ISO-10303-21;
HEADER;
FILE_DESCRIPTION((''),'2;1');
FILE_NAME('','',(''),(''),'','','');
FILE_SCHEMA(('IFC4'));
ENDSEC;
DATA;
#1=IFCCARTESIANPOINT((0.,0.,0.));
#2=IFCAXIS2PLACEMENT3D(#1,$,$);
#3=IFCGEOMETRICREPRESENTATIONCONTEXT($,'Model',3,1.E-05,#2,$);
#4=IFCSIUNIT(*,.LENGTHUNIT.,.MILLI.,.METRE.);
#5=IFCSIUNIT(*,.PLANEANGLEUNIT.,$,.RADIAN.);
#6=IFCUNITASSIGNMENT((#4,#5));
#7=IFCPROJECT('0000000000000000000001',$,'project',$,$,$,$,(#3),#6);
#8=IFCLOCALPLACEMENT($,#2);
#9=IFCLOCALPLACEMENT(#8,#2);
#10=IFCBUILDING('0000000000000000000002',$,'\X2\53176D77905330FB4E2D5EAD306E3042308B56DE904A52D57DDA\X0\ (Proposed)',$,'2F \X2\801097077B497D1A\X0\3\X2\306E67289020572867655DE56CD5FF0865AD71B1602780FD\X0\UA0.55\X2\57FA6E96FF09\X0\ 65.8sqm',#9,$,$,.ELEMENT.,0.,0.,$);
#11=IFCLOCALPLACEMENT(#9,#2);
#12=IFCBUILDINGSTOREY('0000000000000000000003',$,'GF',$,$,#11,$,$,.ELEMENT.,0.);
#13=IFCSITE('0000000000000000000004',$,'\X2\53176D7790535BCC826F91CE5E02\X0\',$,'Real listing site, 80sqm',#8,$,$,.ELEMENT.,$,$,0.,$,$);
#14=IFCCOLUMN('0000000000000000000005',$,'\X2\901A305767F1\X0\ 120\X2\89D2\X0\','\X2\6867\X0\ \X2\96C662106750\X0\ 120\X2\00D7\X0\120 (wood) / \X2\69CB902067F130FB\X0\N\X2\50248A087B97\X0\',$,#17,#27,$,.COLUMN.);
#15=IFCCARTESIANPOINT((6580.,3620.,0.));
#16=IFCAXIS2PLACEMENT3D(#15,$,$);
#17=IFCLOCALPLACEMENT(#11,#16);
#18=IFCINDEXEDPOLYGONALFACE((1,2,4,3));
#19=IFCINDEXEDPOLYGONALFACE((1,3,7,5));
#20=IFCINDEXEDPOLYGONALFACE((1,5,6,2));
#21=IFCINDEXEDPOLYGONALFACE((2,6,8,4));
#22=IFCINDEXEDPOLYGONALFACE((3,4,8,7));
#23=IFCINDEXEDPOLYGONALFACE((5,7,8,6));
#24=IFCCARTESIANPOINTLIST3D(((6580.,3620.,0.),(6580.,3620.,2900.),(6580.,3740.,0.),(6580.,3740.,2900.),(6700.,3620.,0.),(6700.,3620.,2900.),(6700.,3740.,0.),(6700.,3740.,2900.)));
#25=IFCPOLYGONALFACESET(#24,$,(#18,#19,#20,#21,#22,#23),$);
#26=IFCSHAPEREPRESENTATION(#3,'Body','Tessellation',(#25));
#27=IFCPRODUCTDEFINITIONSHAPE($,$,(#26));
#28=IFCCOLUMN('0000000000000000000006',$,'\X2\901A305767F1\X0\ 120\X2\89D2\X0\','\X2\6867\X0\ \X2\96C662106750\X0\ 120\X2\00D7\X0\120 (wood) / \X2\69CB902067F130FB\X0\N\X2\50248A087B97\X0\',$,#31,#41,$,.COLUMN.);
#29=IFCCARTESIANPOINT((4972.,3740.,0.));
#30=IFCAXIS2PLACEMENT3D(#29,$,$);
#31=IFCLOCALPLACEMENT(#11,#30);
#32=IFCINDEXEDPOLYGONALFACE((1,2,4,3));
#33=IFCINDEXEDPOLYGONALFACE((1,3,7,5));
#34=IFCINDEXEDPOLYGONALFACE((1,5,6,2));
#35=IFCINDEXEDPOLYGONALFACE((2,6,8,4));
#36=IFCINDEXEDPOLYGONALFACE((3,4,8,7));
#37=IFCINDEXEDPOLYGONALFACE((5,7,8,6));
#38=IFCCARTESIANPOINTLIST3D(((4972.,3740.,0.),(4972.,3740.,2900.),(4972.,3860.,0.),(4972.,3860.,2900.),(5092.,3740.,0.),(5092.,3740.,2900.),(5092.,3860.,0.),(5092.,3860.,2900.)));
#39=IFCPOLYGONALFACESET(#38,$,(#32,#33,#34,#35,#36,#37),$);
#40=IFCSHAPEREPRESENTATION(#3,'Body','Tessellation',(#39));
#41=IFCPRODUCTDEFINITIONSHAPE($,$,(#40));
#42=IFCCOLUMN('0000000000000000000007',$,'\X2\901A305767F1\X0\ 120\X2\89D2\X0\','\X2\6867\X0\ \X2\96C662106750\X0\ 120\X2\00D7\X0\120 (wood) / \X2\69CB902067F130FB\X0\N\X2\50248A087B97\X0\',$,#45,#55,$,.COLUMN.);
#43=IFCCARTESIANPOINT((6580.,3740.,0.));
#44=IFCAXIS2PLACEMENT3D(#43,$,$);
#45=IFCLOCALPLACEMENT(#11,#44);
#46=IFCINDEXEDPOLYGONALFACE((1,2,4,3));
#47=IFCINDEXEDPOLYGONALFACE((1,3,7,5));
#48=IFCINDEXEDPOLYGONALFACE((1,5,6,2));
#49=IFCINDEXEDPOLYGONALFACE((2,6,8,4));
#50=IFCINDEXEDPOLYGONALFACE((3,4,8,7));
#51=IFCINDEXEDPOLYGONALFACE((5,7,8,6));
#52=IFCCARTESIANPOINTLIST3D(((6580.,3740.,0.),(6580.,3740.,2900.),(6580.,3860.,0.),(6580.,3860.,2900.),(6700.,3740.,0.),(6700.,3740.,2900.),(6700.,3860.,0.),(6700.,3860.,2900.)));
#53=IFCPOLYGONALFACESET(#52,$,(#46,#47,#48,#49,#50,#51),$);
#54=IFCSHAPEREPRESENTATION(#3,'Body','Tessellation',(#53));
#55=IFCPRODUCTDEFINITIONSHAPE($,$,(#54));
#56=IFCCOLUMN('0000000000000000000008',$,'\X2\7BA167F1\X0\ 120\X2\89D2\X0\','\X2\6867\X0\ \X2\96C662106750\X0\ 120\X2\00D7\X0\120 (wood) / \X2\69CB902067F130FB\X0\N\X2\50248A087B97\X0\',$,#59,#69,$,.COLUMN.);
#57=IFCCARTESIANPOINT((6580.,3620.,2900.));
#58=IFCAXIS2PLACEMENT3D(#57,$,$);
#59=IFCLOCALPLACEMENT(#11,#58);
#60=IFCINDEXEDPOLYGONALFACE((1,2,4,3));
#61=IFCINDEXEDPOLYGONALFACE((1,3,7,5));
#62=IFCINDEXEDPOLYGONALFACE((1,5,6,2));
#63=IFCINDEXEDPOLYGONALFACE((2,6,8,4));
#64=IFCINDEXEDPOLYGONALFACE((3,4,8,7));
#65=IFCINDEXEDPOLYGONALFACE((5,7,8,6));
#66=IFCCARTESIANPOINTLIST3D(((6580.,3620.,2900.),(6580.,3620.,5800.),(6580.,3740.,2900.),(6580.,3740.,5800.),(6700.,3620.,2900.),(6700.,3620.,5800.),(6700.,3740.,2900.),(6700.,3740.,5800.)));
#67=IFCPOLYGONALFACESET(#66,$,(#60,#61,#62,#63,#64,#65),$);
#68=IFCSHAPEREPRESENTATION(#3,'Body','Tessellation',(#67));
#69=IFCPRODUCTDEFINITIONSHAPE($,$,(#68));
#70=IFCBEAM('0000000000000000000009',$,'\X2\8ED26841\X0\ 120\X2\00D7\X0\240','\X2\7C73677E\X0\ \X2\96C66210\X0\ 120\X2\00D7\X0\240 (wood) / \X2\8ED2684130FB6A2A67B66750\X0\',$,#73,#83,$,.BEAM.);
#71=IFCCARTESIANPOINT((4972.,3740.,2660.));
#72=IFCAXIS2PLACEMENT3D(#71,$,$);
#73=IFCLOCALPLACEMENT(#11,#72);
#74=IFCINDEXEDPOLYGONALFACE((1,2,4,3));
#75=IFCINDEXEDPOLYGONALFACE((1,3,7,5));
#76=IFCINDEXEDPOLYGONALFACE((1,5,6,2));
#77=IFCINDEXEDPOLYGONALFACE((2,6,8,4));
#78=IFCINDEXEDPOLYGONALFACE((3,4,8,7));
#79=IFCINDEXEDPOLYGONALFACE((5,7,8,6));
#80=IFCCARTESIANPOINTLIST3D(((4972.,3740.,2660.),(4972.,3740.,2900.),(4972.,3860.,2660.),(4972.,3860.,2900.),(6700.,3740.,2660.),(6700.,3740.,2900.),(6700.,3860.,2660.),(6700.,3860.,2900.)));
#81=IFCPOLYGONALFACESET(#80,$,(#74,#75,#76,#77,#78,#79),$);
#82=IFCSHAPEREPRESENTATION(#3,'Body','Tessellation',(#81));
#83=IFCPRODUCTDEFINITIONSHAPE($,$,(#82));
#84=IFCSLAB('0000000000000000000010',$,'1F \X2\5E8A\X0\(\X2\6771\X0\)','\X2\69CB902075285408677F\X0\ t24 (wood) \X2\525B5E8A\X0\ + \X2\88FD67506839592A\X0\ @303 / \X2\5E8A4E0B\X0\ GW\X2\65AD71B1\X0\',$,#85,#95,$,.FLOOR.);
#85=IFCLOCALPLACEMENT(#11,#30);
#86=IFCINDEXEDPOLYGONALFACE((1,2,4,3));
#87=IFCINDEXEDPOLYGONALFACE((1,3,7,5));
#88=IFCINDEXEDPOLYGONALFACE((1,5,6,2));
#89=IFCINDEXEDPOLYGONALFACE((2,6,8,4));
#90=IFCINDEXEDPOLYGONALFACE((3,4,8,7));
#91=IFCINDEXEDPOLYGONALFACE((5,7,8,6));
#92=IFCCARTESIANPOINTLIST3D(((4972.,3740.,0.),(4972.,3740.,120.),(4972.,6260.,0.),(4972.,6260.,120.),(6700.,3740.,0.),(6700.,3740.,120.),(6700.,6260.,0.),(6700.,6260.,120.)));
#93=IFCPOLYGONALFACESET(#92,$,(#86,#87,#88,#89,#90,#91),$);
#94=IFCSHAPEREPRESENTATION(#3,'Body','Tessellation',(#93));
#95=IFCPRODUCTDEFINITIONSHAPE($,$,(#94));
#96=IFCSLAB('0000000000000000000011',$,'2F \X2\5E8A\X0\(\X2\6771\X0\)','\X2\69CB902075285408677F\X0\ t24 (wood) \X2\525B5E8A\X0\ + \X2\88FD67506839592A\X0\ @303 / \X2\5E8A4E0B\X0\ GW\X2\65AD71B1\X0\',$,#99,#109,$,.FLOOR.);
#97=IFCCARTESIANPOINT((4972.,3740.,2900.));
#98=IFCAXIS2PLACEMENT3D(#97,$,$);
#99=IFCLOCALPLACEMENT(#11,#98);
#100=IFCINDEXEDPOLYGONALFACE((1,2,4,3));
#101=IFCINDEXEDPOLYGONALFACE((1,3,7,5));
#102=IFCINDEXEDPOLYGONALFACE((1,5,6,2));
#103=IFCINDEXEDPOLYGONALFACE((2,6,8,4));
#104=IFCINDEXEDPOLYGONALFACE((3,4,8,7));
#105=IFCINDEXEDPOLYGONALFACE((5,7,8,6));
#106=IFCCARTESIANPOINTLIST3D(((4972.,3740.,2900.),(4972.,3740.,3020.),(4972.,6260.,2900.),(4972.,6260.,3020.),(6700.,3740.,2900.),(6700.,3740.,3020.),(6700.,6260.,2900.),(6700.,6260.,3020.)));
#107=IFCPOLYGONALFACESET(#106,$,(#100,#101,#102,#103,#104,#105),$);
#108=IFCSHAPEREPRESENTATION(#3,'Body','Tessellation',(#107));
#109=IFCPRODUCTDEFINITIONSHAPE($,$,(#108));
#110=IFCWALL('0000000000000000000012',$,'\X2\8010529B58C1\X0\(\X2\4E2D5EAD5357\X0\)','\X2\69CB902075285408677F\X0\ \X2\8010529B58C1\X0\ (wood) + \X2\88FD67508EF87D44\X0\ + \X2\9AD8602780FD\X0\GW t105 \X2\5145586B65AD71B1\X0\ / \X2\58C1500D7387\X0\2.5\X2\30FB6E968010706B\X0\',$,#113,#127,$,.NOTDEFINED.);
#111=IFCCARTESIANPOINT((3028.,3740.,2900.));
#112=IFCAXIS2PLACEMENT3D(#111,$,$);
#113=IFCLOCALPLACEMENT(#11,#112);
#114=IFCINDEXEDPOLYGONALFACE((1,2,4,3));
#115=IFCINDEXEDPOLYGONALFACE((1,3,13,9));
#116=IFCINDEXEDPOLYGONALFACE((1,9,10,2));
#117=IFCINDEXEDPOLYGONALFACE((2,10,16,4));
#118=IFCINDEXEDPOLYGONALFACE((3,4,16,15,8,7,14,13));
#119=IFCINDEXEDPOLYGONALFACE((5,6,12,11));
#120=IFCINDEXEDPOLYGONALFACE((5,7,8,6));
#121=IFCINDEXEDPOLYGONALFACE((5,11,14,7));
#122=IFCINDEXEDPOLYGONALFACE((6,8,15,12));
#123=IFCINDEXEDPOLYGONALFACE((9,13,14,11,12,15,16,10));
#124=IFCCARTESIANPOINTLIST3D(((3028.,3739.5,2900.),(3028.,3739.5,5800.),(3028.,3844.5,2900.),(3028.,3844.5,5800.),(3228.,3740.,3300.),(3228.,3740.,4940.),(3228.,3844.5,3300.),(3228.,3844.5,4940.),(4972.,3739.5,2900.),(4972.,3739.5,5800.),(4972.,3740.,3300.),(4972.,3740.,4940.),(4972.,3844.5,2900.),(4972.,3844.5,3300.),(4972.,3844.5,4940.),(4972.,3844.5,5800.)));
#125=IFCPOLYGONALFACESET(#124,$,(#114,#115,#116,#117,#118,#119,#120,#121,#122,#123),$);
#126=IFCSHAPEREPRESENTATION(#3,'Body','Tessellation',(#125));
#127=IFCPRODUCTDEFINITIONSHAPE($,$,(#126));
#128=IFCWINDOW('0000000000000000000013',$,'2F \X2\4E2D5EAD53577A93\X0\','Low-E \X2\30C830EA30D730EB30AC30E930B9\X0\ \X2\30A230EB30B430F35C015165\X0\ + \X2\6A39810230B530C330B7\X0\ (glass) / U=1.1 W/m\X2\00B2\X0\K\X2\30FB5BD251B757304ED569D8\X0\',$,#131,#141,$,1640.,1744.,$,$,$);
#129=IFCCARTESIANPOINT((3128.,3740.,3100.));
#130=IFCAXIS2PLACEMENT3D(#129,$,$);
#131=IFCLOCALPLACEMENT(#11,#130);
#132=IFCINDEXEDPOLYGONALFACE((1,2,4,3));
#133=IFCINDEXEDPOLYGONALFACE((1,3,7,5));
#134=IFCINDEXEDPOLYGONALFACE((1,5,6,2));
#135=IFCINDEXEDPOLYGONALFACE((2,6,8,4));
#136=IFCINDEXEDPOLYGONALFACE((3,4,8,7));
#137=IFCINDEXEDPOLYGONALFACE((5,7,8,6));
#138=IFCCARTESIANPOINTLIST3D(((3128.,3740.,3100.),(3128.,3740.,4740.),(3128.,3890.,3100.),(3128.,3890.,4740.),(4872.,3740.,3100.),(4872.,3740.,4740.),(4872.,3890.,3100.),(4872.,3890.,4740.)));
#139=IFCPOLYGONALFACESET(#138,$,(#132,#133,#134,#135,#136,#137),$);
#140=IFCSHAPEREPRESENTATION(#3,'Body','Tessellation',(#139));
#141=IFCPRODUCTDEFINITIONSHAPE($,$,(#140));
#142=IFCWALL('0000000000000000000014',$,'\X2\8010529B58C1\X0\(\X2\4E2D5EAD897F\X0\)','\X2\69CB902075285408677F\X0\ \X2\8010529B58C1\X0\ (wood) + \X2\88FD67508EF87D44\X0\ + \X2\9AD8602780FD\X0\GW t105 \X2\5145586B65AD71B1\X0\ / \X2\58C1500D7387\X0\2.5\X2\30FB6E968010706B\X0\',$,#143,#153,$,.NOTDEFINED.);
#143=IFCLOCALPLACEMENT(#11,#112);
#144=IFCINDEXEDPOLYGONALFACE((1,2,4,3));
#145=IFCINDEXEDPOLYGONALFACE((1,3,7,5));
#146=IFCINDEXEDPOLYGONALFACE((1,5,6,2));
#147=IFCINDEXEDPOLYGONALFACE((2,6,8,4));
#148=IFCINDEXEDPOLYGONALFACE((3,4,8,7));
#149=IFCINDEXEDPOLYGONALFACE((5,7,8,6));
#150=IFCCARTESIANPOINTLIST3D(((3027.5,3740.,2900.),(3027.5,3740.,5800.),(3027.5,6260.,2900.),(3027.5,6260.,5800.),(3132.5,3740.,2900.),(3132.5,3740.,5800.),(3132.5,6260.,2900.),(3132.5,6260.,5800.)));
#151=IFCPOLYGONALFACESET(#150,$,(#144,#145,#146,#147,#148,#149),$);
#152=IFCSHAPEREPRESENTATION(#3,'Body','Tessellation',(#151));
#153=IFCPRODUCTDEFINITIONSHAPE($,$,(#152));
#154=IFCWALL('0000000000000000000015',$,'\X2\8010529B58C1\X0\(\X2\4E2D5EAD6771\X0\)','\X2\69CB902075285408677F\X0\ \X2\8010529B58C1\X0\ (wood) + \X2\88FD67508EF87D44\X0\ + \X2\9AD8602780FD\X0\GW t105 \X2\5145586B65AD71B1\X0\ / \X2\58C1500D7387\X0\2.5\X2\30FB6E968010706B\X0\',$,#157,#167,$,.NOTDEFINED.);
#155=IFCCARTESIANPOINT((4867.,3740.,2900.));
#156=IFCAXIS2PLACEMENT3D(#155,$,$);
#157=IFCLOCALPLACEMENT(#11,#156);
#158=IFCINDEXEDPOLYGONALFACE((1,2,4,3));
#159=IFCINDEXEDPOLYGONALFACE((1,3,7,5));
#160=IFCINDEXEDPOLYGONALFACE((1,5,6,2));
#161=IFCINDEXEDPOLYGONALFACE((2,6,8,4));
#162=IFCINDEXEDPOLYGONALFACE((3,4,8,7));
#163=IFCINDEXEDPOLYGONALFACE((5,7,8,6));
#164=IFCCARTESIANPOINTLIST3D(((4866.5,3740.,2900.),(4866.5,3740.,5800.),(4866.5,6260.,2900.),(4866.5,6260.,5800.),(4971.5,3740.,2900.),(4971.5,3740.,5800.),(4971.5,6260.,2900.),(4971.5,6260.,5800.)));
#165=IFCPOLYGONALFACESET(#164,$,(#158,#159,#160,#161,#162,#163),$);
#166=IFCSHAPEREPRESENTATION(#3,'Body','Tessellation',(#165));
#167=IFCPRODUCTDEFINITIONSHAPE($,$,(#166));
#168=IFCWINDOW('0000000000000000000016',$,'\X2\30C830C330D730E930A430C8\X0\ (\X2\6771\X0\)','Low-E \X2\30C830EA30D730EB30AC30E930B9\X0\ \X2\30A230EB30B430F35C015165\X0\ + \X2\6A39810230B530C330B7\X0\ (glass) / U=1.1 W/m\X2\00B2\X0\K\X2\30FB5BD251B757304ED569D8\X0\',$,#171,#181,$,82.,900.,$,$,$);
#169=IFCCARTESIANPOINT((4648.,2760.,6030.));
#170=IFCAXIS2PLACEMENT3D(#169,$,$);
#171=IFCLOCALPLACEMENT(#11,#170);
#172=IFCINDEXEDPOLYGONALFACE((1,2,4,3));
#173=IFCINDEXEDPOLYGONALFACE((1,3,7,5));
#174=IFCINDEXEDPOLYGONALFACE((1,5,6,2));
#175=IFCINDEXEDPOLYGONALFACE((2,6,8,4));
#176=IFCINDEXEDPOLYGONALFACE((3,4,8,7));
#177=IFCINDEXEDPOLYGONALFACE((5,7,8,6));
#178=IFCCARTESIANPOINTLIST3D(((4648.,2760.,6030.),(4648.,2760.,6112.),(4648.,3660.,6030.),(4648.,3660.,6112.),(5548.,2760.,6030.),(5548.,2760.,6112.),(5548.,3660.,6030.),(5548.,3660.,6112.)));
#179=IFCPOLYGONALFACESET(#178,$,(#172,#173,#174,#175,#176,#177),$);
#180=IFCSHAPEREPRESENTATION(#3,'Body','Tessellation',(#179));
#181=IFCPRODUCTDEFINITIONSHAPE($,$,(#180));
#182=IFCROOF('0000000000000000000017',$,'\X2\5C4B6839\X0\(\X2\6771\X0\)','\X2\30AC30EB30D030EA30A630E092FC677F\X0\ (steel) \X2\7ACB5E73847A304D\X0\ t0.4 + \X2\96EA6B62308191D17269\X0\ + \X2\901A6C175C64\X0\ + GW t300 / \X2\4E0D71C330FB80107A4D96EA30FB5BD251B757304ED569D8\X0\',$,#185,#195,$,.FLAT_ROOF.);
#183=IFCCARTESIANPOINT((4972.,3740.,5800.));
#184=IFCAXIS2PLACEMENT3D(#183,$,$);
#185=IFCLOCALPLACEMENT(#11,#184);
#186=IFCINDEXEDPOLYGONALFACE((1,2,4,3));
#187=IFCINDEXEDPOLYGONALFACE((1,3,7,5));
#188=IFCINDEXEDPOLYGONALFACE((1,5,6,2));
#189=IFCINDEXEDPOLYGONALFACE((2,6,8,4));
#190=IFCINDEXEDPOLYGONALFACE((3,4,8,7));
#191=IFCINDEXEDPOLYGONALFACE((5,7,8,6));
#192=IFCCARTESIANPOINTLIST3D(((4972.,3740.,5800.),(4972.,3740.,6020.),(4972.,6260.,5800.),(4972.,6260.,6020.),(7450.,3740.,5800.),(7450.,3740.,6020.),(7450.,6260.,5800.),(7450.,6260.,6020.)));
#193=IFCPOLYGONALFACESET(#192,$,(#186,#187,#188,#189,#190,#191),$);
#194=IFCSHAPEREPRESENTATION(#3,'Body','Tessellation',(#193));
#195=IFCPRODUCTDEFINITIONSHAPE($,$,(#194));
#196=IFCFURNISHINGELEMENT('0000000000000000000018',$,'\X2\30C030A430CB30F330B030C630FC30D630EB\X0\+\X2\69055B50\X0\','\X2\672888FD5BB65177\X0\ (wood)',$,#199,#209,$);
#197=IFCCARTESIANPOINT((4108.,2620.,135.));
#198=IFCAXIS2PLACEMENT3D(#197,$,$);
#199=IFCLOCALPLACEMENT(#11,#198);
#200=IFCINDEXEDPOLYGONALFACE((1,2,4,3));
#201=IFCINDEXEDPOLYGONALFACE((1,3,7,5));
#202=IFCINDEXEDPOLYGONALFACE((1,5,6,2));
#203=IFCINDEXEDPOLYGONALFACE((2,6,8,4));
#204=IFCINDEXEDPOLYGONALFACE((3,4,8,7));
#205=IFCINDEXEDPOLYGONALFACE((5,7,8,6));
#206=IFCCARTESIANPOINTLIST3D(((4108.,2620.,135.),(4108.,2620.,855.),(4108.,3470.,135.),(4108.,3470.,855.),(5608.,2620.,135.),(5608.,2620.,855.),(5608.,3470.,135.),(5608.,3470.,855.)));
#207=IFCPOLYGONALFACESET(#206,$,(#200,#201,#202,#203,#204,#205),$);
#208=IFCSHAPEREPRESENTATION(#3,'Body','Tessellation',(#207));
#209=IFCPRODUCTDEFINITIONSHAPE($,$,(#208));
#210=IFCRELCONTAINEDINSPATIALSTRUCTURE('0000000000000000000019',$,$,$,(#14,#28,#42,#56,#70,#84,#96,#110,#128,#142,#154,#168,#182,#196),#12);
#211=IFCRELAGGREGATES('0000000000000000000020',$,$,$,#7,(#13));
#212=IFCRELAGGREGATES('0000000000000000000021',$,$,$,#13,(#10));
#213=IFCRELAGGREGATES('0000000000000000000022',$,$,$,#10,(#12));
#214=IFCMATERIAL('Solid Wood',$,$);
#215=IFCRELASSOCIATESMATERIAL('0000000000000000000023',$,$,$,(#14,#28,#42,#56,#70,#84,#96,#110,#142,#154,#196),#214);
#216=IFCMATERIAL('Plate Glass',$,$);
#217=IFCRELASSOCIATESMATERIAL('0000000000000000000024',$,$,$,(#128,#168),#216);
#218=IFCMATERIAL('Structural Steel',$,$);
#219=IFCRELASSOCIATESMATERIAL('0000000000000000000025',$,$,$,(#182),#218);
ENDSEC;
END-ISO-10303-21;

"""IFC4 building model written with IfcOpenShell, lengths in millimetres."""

from ifc_helpers import new_model, si_unit, frame, frame_2d, origin, place, context, project, spatial, rectangle, extrude, material, element, fill, save


model = new_model("IFC4")

# Units and contexts
model_context = context("Model", 3, precision=1e-05, world=origin())
ifc_project = project(units=[si_unit("LENGTHUNIT", "METRE", prefix="MILLI"), si_unit("PLANEANGLEUNIT", "RADIAN")], contexts=[model_context])

# Site, building, storey
site_placement = place(None, origin())
site = spatial("IfcSite", under=ifc_project, at=site_placement, Name="北海道富良野市", ObjectType="Real listing site, 80sqm", CompositionType="ELEMENT", RefElevation=0.0)
building_placement = place(site_placement, origin())
building = spatial("IfcBuilding", under=site, at=building_placement, Name="北海道・中庭のある回遊動線 (Proposed)", ObjectType="2F 耐震等級3の木造在来工法（断熱性能UA0.55基準） 65.8sqm", CompositionType="ELEMENT", ElevationOfRefHeight=0.0, ElevationOfTerrain=0.0)
storey_placement = place(building_placement, origin())
storey = spatial("IfcBuildingStorey", under=building, at=storey_placement, Name="GF", CompositionType="ELEMENT", Elevation=0.0)

# Columns
ifc_material_1 = material(Name="Solid Wood")
column_1_placement = place(storey_placement, frame((6580.0, 3620.0, 0.0)))
element("IfcColumn", 1, at=column_1_placement, inside=storey, material=ifc_material_1, Name="通し柱 120角", Description="桧 集成材 120×120 (wood) / 構造柱・N値計算", PredefinedType="COLUMN", context=model_context, shape_type="SweptSolid", body=[
    extrude(rectangle(XDim=120.0, YDim=120.0, at=frame_2d((60.0, 60.0))), frame((6580.0, 3620.0, 0.0)), (0.0, 0.0, 1.0), 2900.0),
])
column_2_placement = place(storey_placement, frame((4972.0, 3740.0, 0.0)))
element("IfcColumn", 2, at=column_2_placement, inside=storey, material=ifc_material_1, Name="通し柱 120角", Description="桧 集成材 120×120 (wood) / 構造柱・N値計算", PredefinedType="COLUMN", context=model_context, shape_type="SweptSolid", body=[
    extrude(rectangle(XDim=120.0, YDim=120.0, at=frame_2d((60.0, 60.0))), frame((4972.0, 3740.0, 0.0)), (0.0, 0.0, 1.0), 2900.0),
])
column_3_placement = place(storey_placement, frame((6580.0, 3740.0, 0.0)))
element("IfcColumn", 3, at=column_3_placement, inside=storey, material=ifc_material_1, Name="通し柱 120角", Description="桧 集成材 120×120 (wood) / 構造柱・N値計算", PredefinedType="COLUMN", context=model_context, shape_type="SweptSolid", body=[
    extrude(rectangle(XDim=120.0, YDim=120.0, at=frame_2d((60.0, 60.0))), frame((6580.0, 3740.0, 0.0)), (0.0, 0.0, 1.0), 2900.0),
])
column_4_placement = place(storey_placement, frame((6580.0, 3620.0, 2900.0)))
element("IfcColumn", 4, at=column_4_placement, inside=storey, material=ifc_material_1, Name="管柱 120角", Description="桧 集成材 120×120 (wood) / 構造柱・N値計算", PredefinedType="COLUMN", context=model_context, shape_type="SweptSolid", body=[
    extrude(rectangle(XDim=120.0, YDim=120.0, at=frame_2d((60.0, 60.0))), frame((6580.0, 3620.0, 2900.0)), (0.0, 0.0, 1.0), 2900.0),
])

# Beam
beam_1_placement = place(storey_placement, frame((4972.0, 3740.0, 2660.0)))
element("IfcBeam", 5, at=beam_1_placement, inside=storey, material=ifc_material_1, Name="軒桁 120×240", Description="米松 集成 120×240 (wood) / 軒桁・横架材", PredefinedType="BEAM", context=model_context, shape_type="SweptSolid", body=[
    extrude(rectangle(XDim=1728.0, YDim=120.0, at=frame_2d((864.0, 60.0))), frame((4972.0, 3740.0, 2660.0)), (0.0, 0.0, 1.0), 240.0),
])

# Slabs
slab_1_placement = place(storey_placement, frame((4972.0, 3740.0, 0.0)))
element("IfcSlab", 6, at=slab_1_placement, inside=storey, material=ifc_material_1, Name="1F 床(東)", Description="構造用合板 t24 (wood) 剛床 + 製材根太 @303 / 床下 GW断熱", PredefinedType="FLOOR", context=model_context, shape_type="SweptSolid", body=[
    extrude(rectangle(XDim=1728.0, YDim=2520.0, at=frame_2d((864.0, 1260.0))), frame((4972.0, 3740.0, 0.0)), (0.0, 0.0, 1.0), 120.0),
])
slab_2_placement = place(storey_placement, frame((4972.0, 3740.0, 2900.0)))
element("IfcSlab", 7, at=slab_2_placement, inside=storey, material=ifc_material_1, Name="2F 床(東)", Description="構造用合板 t24 (wood) 剛床 + 製材根太 @303 / 床下 GW断熱", PredefinedType="FLOOR", context=model_context, shape_type="SweptSolid", body=[
    extrude(rectangle(XDim=1728.0, YDim=2520.0, at=frame_2d((864.0, 1260.0))), frame((4972.0, 3740.0, 2900.0)), (0.0, 0.0, 1.0), 120.0),
])

# Wall, opening, window
wall_1_placement = place(storey_placement, frame((3028.0, 3740.0, 2900.0)))
wall_1 = element("IfcWall", 8, at=wall_1_placement, inside=storey, material=ifc_material_1, Name="耐力壁(中庭南)", Description="構造用合板 耐力壁 (wood) + 製材軸組 + 高性能GW t105 充填断熱 / 壁倍率2.5・準耐火", PredefinedType="NOTDEFINED", context=model_context, shape_type="SweptSolid", body=[
    extrude(rectangle(XDim=1944.0, YDim=105.0, at=frame_2d((972.0, 52.0))), frame((3028.0, 3740.0, 2900.0)), (0.0, 0.0, 1.0), 2900.0),
])
opening_placement = place(storey_placement, frame((3128.0, 3740.0, 3100.0)))
opening = element("IfcOpeningElement", 9, at=opening_placement, cuts=wall_1, PredefinedType="NOTDEFINED", context=model_context, shape_type="SweptSolid", body=[
    extrude(rectangle(XDim=1744.0, YDim=150.0, at=frame_2d((872.0, 75.0))), frame((3128.0, 3740.0, 3100.0)), (0.0, 0.0, 1.0), 1640.0),
])
ifc_material_2 = material(Name="Plate Glass")
window_1_placement = place(storey_placement, frame((3128.0, 3740.0, 3100.0)))
window_1 = element("IfcWindow", 10, at=window_1_placement, inside=storey, material=ifc_material_2, Name="2F 中庭南窓", Description="Low-E トリプルガラス アルゴン封入 + 樹脂サッシ (glass) / U=1.1 W/m²K・寒冷地仕様", OverallHeight=1640.0, OverallWidth=1744.0, context=model_context, shape_type="SweptSolid", body=[
    extrude(rectangle(XDim=1744.0, YDim=150.0, at=frame_2d((872.0, 75.0))), frame((3128.0, 3740.0, 3100.0)), (0.0, 0.0, 1.0), 1640.0),
])
fill(opening, window_1)

# Walls
wall_2_placement = place(storey_placement, frame((3028.0, 3740.0, 2900.0)))
element("IfcWall", 11, at=wall_2_placement, inside=storey, material=ifc_material_1, Name="耐力壁(中庭西)", Description="構造用合板 耐力壁 (wood) + 製材軸組 + 高性能GW t105 充填断熱 / 壁倍率2.5・準耐火", PredefinedType="NOTDEFINED", context=model_context, shape_type="SweptSolid", body=[
    extrude(rectangle(XDim=105.0, YDim=2520.0, at=frame_2d((52.0, 1260.0))), frame((3028.0, 3740.0, 2900.0)), (0.0, 0.0, 1.0), 2900.0),
])
wall_3_placement = place(storey_placement, frame((4867.0, 3740.0, 2900.0)))
element("IfcWall", 12, at=wall_3_placement, inside=storey, material=ifc_material_1, Name="耐力壁(中庭東)", Description="構造用合板 耐力壁 (wood) + 製材軸組 + 高性能GW t105 充填断熱 / 壁倍率2.5・準耐火", PredefinedType="NOTDEFINED", context=model_context, shape_type="SweptSolid", body=[
    extrude(rectangle(XDim=105.0, YDim=2520.0, at=frame_2d((52.0, 1260.0))), frame((4867.0, 3740.0, 2900.0)), (0.0, 0.0, 1.0), 2900.0),
])

# Window
window_2_placement = place(storey_placement, frame((4648.0, 2760.0, 6030.0)))
element("IfcWindow", 13, at=window_2_placement, inside=storey, material=ifc_material_2, Name="トップライト (東)", Description="Low-E トリプルガラス アルゴン封入 + 樹脂サッシ (glass) / U=1.1 W/m²K・寒冷地仕様", OverallHeight=82.0, OverallWidth=900.0, context=model_context, shape_type="SweptSolid", body=[
    extrude(rectangle(XDim=900.0, YDim=900.0, at=frame_2d((450.0, 450.0))), frame((4648.0, 2760.0, 6030.0)), (0.0, 0.0, 1.0), 82.0),
])

# Roof
ifc_material_3 = material(Name="Structural Steel")
for number, where, name in (
    (14, (4972.0, 3740.0, 5800.0), "屋根(東)"),
):
    element("IfcRoof", number, at=place(storey_placement, frame(where)), inside=storey, material=ifc_material_3, Name=name, Description="ガルバリウム鋼板 (steel) 立平葺き t0.4 + 雪止め金物 + 通気層 + GW t300 / 不燃・耐積雪・寒冷地仕様", PredefinedType="FLAT_ROOF", context=model_context, shape_type="SweptSolid", body=[
        extrude(rectangle(XDim=2478.0, YDim=2520.0, at=frame_2d((1239.0, 1260.0))), frame((4972.0, 3740.0, 5800.0)), (0.0, 0.0, 1.0), 220.0),
    ])

# Furnishing element
furnishing_1_placement = place(storey_placement, frame((4108.0, 2620.0, 135.0)))
element("IfcFurnishingElement", 15, at=furnishing_1_placement, inside=storey, material=ifc_material_1, Name="ダイニングテーブル+椅子", Description="木製家具 (wood)", context=model_context, shape_type="SweptSolid", body=[
    extrude(rectangle(XDim=1500.0, YDim=850.0, at=frame_2d((750.0, 425.0))), frame((4108.0, 2620.0, 135.0)), (0.0, 0.0, 1.0), 720.0),
])

save(model, "model.ifc")
